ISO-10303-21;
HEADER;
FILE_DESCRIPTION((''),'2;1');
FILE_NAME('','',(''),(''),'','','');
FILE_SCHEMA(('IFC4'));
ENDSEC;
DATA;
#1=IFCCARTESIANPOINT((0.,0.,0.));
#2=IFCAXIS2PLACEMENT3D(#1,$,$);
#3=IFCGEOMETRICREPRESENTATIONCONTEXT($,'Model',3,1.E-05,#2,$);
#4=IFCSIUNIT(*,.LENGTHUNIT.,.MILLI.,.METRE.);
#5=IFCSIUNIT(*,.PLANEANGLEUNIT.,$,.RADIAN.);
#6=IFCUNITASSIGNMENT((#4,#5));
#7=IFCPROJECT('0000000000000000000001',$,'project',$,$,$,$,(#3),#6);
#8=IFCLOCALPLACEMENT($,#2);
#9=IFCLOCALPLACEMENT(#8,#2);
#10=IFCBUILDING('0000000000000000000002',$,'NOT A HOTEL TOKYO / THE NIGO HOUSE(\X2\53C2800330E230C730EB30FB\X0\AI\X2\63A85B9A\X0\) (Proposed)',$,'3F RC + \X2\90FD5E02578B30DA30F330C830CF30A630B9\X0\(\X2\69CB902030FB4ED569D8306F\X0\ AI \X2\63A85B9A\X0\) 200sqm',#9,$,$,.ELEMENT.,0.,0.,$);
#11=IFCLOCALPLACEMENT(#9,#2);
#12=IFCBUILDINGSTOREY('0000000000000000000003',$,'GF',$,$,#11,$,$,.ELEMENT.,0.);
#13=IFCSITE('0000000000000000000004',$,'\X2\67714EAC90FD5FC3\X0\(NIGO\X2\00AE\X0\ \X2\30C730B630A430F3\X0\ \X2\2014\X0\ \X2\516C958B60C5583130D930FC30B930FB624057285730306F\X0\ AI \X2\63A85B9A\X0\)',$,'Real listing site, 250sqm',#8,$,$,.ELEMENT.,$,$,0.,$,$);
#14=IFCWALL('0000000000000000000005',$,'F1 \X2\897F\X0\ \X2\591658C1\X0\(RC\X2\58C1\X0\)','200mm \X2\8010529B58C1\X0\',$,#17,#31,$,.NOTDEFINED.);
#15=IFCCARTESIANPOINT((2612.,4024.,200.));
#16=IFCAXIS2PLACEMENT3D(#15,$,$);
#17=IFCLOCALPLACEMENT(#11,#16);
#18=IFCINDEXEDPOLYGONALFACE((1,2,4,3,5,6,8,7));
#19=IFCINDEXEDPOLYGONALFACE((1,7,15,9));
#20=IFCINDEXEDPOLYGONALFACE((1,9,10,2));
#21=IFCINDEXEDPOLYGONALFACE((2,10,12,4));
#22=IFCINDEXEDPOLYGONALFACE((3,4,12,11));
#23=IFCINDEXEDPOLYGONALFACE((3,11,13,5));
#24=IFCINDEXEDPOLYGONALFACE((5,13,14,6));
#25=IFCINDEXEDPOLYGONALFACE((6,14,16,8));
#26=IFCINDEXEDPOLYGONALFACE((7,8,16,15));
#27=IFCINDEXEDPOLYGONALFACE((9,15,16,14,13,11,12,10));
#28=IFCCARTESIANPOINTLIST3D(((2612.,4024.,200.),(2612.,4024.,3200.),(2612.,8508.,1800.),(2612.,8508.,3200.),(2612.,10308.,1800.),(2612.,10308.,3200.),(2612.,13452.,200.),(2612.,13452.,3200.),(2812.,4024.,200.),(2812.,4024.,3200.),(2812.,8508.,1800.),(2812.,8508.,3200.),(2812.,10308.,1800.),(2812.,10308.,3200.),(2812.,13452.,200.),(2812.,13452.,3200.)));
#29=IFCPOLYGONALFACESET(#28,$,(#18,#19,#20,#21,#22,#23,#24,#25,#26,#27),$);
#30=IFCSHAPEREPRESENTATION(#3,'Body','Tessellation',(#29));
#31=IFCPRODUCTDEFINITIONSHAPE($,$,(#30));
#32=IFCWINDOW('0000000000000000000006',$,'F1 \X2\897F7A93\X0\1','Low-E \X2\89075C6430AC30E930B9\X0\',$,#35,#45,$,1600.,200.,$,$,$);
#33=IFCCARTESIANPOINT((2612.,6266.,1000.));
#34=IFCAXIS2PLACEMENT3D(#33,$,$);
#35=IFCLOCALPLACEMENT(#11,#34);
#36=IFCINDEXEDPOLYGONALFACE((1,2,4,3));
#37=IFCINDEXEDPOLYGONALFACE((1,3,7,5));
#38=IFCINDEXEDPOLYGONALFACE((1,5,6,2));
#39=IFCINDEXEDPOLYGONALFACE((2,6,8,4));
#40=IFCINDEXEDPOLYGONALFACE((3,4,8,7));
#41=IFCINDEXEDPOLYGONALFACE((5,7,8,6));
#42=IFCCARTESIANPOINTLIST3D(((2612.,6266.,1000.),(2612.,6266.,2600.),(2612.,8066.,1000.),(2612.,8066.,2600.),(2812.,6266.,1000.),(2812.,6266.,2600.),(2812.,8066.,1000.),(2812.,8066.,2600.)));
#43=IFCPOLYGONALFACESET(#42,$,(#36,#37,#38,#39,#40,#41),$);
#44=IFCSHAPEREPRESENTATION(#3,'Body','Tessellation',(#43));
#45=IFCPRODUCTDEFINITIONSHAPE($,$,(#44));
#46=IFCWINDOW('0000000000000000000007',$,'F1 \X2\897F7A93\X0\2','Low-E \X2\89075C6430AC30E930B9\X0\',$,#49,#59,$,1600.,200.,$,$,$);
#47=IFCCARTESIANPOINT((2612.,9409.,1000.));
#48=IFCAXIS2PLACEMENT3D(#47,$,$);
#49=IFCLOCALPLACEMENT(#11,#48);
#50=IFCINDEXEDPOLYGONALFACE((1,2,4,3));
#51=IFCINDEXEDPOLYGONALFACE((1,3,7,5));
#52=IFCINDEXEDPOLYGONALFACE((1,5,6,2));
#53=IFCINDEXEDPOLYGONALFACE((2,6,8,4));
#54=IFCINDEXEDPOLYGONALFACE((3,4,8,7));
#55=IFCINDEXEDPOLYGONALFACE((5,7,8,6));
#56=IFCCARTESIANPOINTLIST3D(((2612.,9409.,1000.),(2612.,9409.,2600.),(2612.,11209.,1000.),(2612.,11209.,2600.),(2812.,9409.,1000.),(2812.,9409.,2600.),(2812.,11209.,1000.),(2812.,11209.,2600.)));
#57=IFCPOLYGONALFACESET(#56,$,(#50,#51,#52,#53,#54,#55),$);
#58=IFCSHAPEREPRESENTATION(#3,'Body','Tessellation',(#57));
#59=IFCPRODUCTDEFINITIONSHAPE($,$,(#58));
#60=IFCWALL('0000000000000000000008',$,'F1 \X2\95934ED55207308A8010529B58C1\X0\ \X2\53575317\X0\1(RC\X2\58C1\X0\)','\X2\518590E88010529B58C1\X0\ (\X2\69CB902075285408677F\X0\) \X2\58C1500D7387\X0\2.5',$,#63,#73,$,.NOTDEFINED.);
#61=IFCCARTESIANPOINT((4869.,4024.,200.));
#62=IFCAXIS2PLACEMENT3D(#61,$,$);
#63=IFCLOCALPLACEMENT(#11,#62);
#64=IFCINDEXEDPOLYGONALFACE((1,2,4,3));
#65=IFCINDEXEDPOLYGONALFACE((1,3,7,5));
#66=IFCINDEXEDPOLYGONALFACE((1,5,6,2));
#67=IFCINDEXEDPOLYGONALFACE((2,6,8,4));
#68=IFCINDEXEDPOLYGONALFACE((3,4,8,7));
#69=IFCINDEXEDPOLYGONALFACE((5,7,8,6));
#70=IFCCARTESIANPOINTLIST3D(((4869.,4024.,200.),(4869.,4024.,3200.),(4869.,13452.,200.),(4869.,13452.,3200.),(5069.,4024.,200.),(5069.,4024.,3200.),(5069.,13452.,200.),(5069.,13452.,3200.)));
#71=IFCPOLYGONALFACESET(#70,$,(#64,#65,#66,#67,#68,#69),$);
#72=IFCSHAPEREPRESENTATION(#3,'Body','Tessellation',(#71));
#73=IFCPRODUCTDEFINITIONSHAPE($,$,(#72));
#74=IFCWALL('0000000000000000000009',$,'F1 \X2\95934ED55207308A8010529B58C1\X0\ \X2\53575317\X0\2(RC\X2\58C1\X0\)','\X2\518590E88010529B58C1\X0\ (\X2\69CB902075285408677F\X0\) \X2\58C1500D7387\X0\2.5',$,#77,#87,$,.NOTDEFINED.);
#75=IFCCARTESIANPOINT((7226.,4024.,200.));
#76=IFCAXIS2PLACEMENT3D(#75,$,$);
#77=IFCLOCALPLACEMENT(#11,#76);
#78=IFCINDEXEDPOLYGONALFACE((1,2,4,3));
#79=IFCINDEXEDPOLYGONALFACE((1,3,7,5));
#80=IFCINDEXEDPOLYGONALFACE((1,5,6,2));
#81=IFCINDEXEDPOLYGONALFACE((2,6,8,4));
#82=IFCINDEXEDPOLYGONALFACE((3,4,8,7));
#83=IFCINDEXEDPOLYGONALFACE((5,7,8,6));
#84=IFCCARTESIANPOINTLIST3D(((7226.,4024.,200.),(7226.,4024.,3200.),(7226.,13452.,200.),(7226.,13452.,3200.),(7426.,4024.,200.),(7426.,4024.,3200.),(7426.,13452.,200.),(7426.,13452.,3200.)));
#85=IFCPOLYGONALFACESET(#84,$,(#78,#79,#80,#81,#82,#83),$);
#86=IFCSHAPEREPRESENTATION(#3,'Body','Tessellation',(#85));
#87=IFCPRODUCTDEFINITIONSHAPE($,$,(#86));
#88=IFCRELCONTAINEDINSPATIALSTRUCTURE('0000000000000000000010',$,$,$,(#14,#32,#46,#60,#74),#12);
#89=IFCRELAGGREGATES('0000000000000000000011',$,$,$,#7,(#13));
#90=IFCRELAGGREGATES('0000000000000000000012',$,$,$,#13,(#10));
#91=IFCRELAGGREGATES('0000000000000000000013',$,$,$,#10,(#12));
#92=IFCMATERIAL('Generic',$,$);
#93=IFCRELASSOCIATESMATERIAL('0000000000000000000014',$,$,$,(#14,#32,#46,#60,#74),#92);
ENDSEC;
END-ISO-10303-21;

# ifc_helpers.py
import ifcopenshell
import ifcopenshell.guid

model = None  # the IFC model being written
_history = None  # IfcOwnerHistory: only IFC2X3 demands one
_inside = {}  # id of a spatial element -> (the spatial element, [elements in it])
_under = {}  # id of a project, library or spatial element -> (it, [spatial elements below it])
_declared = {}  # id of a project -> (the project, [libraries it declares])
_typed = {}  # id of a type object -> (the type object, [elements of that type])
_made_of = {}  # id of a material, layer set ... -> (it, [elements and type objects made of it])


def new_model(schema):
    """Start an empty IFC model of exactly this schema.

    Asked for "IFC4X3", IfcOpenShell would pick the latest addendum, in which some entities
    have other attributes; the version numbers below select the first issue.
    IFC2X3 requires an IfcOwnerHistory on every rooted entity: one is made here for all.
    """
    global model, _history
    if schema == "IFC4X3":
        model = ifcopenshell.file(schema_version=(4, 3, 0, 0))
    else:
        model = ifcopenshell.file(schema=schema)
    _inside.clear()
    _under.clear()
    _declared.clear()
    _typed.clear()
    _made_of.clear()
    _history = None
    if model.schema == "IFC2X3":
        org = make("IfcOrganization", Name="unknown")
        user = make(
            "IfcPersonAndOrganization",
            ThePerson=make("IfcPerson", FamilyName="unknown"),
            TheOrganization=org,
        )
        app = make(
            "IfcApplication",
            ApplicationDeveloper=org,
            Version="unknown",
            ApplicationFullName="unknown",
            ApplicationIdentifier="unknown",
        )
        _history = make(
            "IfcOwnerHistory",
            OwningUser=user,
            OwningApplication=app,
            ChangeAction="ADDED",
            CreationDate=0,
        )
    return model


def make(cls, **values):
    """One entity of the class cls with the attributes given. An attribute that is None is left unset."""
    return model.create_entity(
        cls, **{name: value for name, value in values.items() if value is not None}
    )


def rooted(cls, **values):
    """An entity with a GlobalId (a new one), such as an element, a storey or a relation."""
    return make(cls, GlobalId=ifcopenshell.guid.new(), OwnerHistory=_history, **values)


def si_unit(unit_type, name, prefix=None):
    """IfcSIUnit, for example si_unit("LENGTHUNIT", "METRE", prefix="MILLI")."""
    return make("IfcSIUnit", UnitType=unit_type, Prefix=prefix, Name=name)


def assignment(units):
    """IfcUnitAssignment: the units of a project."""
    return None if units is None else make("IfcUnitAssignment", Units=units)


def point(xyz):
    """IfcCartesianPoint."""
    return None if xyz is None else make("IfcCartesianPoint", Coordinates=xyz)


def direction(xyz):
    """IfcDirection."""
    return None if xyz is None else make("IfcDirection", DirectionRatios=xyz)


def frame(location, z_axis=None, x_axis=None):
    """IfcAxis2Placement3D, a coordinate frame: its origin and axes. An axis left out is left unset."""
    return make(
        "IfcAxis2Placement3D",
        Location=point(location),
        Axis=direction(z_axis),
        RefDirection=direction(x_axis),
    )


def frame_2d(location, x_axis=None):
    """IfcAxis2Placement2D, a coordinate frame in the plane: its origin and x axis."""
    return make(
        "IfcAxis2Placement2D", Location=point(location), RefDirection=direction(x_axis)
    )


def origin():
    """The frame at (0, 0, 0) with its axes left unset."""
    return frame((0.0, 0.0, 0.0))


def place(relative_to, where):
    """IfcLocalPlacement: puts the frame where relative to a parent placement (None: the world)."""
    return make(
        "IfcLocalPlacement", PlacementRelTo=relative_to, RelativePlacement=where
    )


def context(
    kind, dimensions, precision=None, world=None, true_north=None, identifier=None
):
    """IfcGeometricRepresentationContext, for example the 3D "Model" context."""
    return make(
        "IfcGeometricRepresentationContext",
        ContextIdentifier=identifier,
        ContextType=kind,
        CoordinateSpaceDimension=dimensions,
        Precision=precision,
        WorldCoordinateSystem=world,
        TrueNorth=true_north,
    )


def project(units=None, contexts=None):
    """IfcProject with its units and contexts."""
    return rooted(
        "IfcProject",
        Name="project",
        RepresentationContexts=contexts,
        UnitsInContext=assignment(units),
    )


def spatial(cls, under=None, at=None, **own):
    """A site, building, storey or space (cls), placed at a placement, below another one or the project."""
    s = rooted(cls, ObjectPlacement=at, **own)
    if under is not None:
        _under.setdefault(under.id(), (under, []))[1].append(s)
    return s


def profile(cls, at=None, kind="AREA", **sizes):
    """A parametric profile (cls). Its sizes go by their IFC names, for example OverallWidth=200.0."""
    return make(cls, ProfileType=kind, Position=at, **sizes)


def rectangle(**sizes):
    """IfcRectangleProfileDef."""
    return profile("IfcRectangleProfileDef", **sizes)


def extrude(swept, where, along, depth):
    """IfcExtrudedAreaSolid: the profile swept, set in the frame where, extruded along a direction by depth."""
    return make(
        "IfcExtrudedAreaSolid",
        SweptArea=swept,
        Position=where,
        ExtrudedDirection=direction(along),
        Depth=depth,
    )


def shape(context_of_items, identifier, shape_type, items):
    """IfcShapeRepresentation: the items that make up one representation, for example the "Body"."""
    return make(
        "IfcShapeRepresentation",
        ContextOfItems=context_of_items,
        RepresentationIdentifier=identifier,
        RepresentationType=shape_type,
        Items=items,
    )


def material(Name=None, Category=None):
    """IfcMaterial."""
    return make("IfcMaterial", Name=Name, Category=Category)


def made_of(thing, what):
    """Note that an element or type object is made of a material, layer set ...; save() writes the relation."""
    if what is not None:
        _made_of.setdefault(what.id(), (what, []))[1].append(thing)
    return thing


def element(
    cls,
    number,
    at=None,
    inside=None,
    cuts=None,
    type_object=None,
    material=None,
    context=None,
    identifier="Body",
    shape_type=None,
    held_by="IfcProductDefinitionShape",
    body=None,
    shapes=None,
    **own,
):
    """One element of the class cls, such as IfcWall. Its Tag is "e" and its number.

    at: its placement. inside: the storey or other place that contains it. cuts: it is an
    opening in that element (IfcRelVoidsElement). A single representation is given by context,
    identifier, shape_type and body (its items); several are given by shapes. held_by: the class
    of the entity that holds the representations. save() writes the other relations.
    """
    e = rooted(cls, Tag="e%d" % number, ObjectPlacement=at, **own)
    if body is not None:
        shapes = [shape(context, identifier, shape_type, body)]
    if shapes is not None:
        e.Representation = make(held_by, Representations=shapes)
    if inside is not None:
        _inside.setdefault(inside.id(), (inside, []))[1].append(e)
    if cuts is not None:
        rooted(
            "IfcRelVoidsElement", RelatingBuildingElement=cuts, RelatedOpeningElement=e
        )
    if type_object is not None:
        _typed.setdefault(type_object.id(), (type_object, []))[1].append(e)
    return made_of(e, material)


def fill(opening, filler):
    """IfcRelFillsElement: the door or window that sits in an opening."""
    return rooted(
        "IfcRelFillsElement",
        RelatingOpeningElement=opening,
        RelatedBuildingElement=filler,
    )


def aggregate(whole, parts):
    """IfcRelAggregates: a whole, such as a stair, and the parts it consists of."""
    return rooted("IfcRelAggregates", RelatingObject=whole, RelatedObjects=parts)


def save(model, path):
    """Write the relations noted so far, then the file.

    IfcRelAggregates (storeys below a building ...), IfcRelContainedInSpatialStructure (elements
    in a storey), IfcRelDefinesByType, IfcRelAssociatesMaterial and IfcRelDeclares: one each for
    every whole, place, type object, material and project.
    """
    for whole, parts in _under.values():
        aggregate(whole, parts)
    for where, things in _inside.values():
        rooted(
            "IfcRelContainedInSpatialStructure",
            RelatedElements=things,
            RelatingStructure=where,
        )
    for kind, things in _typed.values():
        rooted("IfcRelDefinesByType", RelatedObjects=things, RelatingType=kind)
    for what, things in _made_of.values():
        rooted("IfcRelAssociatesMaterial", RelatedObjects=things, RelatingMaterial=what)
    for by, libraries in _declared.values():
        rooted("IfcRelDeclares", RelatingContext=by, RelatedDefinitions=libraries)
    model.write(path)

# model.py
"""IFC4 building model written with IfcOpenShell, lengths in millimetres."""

from ifc_helpers import new_model, si_unit, frame, frame_2d, origin, place, context, project, spatial, rectangle, extrude, material, element, fill, save


model = new_model("IFC4")

# Units and contexts
model_context = context("Model", 3, precision=1e-05, world=origin())
ifc_project = project(units=[si_unit("LENGTHUNIT", "METRE", prefix="MILLI"), si_unit("PLANEANGLEUNIT", "RADIAN")], contexts=[model_context])

# Site, building, storey
site_placement = place(None, origin())
site = spatial("IfcSite", under=ifc_project, at=site_placement, Name="東京都心(NIGO® デザイン — 公開情報ベース・所在地は AI 推定)", ObjectType="Real listing site, 250sqm", CompositionType="ELEMENT", RefElevation=0.0)
building_placement = place(site_placement, origin())
building = spatial("IfcBuilding", under=site, at=building_placement, Name="NOT A HOTEL TOKYO / THE NIGO HOUSE(参考モデル・AI推定) (Proposed)", ObjectType="3F RC + 都市型ペントハウス(構造・仕様は AI 推定) 200sqm", CompositionType="ELEMENT", ElevationOfRefHeight=0.0, ElevationOfTerrain=0.0)
storey_placement = place(building_placement, origin())
storey = spatial("IfcBuildingStorey", under=building, at=storey_placement, Name="GF", CompositionType="ELEMENT", Elevation=0.0)

# Shared definitions
ifc_material_1 = material(Name="Generic")

# Wall, openings, windows
wall_1_placement = place(storey_placement, frame((2612.0, 4024.0, 200.0)))
wall_1 = element("IfcWall", 1, at=wall_1_placement, inside=storey, material=ifc_material_1, Name="F1 西 外壁(RC壁)", Description="200mm 耐力壁", PredefinedType="NOTDEFINED", context=model_context, shape_type="SweptSolid", body=[
    extrude(rectangle(XDim=200.0, YDim=9428.0, at=frame_2d((100.0, 4714.0))), frame((2612.0, 4024.0, 200.0)), (0.0, 0.0, 1.0), 3000.0),
])
opening_1_placement = place(storey_placement, frame((2612.0, 6266.0, 1000.0)))
opening_1 = element("IfcOpeningElement", 2, at=opening_1_placement, cuts=wall_1, PredefinedType="NOTDEFINED", context=model_context, shape_type="SweptSolid", body=[
    extrude(rectangle(XDim=200.0, YDim=1800.0, at=frame_2d((100.0, 900.0))), frame((2612.0, 6266.0, 1000.0)), (0.0, 0.0, 1.0), 1600.0),
])
opening_2_placement = place(storey_placement, frame((2612.0, 9409.0, 1000.0)))
opening_2 = element("IfcOpeningElement", 3, at=opening_2_placement, cuts=wall_1, PredefinedType="NOTDEFINED", context=model_context, shape_type="SweptSolid", body=[
    extrude(rectangle(XDim=200.0, YDim=1800.0, at=frame_2d((100.0, 900.0))), frame((2612.0, 9409.0, 1000.0)), (0.0, 0.0, 1.0), 1600.0),
])
window_1_placement = place(storey_placement, frame((2612.0, 6266.0, 1000.0)))
window_1 = element("IfcWindow", 4, at=window_1_placement, inside=storey, material=ifc_material_1, Name="F1 西窓1", Description="Low-E 複層ガラス", OverallHeight=1600.0, OverallWidth=200.0, context=model_context, shape_type="SweptSolid", body=[
    extrude(rectangle(XDim=200.0, YDim=1800.0, at=frame_2d((100.0, 900.0))), frame((2612.0, 6266.0, 1000.0)), (0.0, 0.0, 1.0), 1600.0),
])
fill(opening_1, window_1)
window_2_placement = place(storey_placement, frame((2612.0, 9409.0, 1000.0)))
window_2 = element("IfcWindow", 5, at=window_2_placement, inside=storey, material=ifc_material_1, Name="F1 西窓2", Description="Low-E 複層ガラス", OverallHeight=1600.0, OverallWidth=200.0, context=model_context, shape_type="SweptSolid", body=[
    extrude(rectangle(XDim=200.0, YDim=1800.0, at=frame_2d((100.0, 900.0))), frame((2612.0, 9409.0, 1000.0)), (0.0, 0.0, 1.0), 1600.0),
])
fill(opening_2, window_2)

# Walls
wall_2_placement = place(storey_placement, frame((4869.0, 4024.0, 200.0)))
element("IfcWall", 6, at=wall_2_placement, inside=storey, material=ifc_material_1, Name="F1 間仕切り耐力壁 南北1(RC壁)", Description="内部耐力壁 (構造用合板) 壁倍率2.5", PredefinedType="NOTDEFINED", context=model_context, shape_type="SweptSolid", body=[
    extrude(rectangle(XDim=200.0, YDim=9428.0, at=frame_2d((100.0, 4714.0))), frame((4869.0, 4024.0, 200.0)), (0.0, 0.0, 1.0), 3000.0),
])
wall_3_placement = place(storey_placement, frame((7226.0, 4024.0, 200.0)))
element("IfcWall", 7, at=wall_3_placement, inside=storey, material=ifc_material_1, Name="F1 間仕切り耐力壁 南北2(RC壁)", Description="内部耐力壁 (構造用合板) 壁倍率2.5", PredefinedType="NOTDEFINED", context=model_context, shape_type="SweptSolid", body=[
    extrude(rectangle(XDim=200.0, YDim=9428.0, at=frame_2d((100.0, 4714.0))), frame((7226.0, 4024.0, 200.0)), (0.0, 0.0, 1.0), 3000.0),
])

save(model, "model.ifc")
